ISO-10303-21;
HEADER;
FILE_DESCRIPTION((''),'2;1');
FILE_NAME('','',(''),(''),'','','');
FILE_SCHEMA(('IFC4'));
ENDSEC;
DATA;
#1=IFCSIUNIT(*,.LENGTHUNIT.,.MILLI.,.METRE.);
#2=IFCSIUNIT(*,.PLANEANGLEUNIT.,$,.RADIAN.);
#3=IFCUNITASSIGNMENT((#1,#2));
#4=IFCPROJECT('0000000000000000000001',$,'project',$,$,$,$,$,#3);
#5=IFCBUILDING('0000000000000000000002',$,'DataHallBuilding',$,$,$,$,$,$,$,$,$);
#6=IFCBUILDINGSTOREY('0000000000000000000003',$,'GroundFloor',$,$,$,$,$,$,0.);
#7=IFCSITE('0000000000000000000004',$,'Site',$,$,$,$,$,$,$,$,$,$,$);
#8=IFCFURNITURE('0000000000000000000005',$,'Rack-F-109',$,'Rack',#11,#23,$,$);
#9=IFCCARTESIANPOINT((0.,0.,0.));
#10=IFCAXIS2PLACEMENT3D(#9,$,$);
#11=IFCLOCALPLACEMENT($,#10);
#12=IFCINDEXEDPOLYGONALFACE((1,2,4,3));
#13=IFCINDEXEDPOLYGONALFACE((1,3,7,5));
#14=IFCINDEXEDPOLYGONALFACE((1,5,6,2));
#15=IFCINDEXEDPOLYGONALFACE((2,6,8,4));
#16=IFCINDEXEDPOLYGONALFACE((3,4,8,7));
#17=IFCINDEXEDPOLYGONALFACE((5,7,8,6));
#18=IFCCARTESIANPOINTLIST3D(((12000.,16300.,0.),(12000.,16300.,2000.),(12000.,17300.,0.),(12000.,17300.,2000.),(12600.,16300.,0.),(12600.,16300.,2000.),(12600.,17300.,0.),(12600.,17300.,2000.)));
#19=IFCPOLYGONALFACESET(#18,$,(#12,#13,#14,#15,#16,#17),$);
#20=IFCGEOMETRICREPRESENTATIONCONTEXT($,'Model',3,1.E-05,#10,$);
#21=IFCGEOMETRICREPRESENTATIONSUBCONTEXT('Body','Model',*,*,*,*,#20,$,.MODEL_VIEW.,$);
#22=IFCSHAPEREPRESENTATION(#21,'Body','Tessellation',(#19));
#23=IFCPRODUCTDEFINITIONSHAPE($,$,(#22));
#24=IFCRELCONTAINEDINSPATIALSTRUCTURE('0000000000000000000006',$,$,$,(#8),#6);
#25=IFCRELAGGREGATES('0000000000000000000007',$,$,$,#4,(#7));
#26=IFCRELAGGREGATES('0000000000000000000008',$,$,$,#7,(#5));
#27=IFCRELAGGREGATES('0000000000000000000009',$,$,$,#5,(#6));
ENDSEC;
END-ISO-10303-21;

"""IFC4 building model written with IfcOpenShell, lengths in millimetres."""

from ifc_helpers import new_model, si_unit, frame, origin, place, context, subcontext, project, spatial, rectangle, extrude, element, save


model = new_model("IFC4")

# Units and contexts
model_context = context("Model", 3, precision=1e-05, world=origin())
body_context = subcontext(model_context, "Body", "Model", "MODEL_VIEW")
ifc_project = project(units=[si_unit("LENGTHUNIT", "METRE", prefix="MILLI"), si_unit("PLANEANGLEUNIT", "RADIAN")])

# Site, building, storey
site = spatial("IfcSite", under=ifc_project, Name="Site")
building = spatial("IfcBuilding", under=site, Name="DataHallBuilding")
storey = spatial("IfcBuildingStorey", under=building, Name="GroundFloor", Elevation=0.0)

# Furniture
furniture_1_placement = place(None, origin())
element("IfcFurniture", 1, at=furniture_1_placement, inside=storey, Name="Rack-F-109", ObjectType="Rack", context=body_context, shape_type="SweptSolid", body=[
    extrude(rectangle(XDim=600.0, YDim=1000.0), frame((12300.0, 16800.0, 0.0), z_axis=(0.0, 0.0, 1.0), x_axis=(1.0, 0.0, 0.0)), (0.0, 0.0, 1.0), 2000.0),
])

save(model, "model.ifc")
